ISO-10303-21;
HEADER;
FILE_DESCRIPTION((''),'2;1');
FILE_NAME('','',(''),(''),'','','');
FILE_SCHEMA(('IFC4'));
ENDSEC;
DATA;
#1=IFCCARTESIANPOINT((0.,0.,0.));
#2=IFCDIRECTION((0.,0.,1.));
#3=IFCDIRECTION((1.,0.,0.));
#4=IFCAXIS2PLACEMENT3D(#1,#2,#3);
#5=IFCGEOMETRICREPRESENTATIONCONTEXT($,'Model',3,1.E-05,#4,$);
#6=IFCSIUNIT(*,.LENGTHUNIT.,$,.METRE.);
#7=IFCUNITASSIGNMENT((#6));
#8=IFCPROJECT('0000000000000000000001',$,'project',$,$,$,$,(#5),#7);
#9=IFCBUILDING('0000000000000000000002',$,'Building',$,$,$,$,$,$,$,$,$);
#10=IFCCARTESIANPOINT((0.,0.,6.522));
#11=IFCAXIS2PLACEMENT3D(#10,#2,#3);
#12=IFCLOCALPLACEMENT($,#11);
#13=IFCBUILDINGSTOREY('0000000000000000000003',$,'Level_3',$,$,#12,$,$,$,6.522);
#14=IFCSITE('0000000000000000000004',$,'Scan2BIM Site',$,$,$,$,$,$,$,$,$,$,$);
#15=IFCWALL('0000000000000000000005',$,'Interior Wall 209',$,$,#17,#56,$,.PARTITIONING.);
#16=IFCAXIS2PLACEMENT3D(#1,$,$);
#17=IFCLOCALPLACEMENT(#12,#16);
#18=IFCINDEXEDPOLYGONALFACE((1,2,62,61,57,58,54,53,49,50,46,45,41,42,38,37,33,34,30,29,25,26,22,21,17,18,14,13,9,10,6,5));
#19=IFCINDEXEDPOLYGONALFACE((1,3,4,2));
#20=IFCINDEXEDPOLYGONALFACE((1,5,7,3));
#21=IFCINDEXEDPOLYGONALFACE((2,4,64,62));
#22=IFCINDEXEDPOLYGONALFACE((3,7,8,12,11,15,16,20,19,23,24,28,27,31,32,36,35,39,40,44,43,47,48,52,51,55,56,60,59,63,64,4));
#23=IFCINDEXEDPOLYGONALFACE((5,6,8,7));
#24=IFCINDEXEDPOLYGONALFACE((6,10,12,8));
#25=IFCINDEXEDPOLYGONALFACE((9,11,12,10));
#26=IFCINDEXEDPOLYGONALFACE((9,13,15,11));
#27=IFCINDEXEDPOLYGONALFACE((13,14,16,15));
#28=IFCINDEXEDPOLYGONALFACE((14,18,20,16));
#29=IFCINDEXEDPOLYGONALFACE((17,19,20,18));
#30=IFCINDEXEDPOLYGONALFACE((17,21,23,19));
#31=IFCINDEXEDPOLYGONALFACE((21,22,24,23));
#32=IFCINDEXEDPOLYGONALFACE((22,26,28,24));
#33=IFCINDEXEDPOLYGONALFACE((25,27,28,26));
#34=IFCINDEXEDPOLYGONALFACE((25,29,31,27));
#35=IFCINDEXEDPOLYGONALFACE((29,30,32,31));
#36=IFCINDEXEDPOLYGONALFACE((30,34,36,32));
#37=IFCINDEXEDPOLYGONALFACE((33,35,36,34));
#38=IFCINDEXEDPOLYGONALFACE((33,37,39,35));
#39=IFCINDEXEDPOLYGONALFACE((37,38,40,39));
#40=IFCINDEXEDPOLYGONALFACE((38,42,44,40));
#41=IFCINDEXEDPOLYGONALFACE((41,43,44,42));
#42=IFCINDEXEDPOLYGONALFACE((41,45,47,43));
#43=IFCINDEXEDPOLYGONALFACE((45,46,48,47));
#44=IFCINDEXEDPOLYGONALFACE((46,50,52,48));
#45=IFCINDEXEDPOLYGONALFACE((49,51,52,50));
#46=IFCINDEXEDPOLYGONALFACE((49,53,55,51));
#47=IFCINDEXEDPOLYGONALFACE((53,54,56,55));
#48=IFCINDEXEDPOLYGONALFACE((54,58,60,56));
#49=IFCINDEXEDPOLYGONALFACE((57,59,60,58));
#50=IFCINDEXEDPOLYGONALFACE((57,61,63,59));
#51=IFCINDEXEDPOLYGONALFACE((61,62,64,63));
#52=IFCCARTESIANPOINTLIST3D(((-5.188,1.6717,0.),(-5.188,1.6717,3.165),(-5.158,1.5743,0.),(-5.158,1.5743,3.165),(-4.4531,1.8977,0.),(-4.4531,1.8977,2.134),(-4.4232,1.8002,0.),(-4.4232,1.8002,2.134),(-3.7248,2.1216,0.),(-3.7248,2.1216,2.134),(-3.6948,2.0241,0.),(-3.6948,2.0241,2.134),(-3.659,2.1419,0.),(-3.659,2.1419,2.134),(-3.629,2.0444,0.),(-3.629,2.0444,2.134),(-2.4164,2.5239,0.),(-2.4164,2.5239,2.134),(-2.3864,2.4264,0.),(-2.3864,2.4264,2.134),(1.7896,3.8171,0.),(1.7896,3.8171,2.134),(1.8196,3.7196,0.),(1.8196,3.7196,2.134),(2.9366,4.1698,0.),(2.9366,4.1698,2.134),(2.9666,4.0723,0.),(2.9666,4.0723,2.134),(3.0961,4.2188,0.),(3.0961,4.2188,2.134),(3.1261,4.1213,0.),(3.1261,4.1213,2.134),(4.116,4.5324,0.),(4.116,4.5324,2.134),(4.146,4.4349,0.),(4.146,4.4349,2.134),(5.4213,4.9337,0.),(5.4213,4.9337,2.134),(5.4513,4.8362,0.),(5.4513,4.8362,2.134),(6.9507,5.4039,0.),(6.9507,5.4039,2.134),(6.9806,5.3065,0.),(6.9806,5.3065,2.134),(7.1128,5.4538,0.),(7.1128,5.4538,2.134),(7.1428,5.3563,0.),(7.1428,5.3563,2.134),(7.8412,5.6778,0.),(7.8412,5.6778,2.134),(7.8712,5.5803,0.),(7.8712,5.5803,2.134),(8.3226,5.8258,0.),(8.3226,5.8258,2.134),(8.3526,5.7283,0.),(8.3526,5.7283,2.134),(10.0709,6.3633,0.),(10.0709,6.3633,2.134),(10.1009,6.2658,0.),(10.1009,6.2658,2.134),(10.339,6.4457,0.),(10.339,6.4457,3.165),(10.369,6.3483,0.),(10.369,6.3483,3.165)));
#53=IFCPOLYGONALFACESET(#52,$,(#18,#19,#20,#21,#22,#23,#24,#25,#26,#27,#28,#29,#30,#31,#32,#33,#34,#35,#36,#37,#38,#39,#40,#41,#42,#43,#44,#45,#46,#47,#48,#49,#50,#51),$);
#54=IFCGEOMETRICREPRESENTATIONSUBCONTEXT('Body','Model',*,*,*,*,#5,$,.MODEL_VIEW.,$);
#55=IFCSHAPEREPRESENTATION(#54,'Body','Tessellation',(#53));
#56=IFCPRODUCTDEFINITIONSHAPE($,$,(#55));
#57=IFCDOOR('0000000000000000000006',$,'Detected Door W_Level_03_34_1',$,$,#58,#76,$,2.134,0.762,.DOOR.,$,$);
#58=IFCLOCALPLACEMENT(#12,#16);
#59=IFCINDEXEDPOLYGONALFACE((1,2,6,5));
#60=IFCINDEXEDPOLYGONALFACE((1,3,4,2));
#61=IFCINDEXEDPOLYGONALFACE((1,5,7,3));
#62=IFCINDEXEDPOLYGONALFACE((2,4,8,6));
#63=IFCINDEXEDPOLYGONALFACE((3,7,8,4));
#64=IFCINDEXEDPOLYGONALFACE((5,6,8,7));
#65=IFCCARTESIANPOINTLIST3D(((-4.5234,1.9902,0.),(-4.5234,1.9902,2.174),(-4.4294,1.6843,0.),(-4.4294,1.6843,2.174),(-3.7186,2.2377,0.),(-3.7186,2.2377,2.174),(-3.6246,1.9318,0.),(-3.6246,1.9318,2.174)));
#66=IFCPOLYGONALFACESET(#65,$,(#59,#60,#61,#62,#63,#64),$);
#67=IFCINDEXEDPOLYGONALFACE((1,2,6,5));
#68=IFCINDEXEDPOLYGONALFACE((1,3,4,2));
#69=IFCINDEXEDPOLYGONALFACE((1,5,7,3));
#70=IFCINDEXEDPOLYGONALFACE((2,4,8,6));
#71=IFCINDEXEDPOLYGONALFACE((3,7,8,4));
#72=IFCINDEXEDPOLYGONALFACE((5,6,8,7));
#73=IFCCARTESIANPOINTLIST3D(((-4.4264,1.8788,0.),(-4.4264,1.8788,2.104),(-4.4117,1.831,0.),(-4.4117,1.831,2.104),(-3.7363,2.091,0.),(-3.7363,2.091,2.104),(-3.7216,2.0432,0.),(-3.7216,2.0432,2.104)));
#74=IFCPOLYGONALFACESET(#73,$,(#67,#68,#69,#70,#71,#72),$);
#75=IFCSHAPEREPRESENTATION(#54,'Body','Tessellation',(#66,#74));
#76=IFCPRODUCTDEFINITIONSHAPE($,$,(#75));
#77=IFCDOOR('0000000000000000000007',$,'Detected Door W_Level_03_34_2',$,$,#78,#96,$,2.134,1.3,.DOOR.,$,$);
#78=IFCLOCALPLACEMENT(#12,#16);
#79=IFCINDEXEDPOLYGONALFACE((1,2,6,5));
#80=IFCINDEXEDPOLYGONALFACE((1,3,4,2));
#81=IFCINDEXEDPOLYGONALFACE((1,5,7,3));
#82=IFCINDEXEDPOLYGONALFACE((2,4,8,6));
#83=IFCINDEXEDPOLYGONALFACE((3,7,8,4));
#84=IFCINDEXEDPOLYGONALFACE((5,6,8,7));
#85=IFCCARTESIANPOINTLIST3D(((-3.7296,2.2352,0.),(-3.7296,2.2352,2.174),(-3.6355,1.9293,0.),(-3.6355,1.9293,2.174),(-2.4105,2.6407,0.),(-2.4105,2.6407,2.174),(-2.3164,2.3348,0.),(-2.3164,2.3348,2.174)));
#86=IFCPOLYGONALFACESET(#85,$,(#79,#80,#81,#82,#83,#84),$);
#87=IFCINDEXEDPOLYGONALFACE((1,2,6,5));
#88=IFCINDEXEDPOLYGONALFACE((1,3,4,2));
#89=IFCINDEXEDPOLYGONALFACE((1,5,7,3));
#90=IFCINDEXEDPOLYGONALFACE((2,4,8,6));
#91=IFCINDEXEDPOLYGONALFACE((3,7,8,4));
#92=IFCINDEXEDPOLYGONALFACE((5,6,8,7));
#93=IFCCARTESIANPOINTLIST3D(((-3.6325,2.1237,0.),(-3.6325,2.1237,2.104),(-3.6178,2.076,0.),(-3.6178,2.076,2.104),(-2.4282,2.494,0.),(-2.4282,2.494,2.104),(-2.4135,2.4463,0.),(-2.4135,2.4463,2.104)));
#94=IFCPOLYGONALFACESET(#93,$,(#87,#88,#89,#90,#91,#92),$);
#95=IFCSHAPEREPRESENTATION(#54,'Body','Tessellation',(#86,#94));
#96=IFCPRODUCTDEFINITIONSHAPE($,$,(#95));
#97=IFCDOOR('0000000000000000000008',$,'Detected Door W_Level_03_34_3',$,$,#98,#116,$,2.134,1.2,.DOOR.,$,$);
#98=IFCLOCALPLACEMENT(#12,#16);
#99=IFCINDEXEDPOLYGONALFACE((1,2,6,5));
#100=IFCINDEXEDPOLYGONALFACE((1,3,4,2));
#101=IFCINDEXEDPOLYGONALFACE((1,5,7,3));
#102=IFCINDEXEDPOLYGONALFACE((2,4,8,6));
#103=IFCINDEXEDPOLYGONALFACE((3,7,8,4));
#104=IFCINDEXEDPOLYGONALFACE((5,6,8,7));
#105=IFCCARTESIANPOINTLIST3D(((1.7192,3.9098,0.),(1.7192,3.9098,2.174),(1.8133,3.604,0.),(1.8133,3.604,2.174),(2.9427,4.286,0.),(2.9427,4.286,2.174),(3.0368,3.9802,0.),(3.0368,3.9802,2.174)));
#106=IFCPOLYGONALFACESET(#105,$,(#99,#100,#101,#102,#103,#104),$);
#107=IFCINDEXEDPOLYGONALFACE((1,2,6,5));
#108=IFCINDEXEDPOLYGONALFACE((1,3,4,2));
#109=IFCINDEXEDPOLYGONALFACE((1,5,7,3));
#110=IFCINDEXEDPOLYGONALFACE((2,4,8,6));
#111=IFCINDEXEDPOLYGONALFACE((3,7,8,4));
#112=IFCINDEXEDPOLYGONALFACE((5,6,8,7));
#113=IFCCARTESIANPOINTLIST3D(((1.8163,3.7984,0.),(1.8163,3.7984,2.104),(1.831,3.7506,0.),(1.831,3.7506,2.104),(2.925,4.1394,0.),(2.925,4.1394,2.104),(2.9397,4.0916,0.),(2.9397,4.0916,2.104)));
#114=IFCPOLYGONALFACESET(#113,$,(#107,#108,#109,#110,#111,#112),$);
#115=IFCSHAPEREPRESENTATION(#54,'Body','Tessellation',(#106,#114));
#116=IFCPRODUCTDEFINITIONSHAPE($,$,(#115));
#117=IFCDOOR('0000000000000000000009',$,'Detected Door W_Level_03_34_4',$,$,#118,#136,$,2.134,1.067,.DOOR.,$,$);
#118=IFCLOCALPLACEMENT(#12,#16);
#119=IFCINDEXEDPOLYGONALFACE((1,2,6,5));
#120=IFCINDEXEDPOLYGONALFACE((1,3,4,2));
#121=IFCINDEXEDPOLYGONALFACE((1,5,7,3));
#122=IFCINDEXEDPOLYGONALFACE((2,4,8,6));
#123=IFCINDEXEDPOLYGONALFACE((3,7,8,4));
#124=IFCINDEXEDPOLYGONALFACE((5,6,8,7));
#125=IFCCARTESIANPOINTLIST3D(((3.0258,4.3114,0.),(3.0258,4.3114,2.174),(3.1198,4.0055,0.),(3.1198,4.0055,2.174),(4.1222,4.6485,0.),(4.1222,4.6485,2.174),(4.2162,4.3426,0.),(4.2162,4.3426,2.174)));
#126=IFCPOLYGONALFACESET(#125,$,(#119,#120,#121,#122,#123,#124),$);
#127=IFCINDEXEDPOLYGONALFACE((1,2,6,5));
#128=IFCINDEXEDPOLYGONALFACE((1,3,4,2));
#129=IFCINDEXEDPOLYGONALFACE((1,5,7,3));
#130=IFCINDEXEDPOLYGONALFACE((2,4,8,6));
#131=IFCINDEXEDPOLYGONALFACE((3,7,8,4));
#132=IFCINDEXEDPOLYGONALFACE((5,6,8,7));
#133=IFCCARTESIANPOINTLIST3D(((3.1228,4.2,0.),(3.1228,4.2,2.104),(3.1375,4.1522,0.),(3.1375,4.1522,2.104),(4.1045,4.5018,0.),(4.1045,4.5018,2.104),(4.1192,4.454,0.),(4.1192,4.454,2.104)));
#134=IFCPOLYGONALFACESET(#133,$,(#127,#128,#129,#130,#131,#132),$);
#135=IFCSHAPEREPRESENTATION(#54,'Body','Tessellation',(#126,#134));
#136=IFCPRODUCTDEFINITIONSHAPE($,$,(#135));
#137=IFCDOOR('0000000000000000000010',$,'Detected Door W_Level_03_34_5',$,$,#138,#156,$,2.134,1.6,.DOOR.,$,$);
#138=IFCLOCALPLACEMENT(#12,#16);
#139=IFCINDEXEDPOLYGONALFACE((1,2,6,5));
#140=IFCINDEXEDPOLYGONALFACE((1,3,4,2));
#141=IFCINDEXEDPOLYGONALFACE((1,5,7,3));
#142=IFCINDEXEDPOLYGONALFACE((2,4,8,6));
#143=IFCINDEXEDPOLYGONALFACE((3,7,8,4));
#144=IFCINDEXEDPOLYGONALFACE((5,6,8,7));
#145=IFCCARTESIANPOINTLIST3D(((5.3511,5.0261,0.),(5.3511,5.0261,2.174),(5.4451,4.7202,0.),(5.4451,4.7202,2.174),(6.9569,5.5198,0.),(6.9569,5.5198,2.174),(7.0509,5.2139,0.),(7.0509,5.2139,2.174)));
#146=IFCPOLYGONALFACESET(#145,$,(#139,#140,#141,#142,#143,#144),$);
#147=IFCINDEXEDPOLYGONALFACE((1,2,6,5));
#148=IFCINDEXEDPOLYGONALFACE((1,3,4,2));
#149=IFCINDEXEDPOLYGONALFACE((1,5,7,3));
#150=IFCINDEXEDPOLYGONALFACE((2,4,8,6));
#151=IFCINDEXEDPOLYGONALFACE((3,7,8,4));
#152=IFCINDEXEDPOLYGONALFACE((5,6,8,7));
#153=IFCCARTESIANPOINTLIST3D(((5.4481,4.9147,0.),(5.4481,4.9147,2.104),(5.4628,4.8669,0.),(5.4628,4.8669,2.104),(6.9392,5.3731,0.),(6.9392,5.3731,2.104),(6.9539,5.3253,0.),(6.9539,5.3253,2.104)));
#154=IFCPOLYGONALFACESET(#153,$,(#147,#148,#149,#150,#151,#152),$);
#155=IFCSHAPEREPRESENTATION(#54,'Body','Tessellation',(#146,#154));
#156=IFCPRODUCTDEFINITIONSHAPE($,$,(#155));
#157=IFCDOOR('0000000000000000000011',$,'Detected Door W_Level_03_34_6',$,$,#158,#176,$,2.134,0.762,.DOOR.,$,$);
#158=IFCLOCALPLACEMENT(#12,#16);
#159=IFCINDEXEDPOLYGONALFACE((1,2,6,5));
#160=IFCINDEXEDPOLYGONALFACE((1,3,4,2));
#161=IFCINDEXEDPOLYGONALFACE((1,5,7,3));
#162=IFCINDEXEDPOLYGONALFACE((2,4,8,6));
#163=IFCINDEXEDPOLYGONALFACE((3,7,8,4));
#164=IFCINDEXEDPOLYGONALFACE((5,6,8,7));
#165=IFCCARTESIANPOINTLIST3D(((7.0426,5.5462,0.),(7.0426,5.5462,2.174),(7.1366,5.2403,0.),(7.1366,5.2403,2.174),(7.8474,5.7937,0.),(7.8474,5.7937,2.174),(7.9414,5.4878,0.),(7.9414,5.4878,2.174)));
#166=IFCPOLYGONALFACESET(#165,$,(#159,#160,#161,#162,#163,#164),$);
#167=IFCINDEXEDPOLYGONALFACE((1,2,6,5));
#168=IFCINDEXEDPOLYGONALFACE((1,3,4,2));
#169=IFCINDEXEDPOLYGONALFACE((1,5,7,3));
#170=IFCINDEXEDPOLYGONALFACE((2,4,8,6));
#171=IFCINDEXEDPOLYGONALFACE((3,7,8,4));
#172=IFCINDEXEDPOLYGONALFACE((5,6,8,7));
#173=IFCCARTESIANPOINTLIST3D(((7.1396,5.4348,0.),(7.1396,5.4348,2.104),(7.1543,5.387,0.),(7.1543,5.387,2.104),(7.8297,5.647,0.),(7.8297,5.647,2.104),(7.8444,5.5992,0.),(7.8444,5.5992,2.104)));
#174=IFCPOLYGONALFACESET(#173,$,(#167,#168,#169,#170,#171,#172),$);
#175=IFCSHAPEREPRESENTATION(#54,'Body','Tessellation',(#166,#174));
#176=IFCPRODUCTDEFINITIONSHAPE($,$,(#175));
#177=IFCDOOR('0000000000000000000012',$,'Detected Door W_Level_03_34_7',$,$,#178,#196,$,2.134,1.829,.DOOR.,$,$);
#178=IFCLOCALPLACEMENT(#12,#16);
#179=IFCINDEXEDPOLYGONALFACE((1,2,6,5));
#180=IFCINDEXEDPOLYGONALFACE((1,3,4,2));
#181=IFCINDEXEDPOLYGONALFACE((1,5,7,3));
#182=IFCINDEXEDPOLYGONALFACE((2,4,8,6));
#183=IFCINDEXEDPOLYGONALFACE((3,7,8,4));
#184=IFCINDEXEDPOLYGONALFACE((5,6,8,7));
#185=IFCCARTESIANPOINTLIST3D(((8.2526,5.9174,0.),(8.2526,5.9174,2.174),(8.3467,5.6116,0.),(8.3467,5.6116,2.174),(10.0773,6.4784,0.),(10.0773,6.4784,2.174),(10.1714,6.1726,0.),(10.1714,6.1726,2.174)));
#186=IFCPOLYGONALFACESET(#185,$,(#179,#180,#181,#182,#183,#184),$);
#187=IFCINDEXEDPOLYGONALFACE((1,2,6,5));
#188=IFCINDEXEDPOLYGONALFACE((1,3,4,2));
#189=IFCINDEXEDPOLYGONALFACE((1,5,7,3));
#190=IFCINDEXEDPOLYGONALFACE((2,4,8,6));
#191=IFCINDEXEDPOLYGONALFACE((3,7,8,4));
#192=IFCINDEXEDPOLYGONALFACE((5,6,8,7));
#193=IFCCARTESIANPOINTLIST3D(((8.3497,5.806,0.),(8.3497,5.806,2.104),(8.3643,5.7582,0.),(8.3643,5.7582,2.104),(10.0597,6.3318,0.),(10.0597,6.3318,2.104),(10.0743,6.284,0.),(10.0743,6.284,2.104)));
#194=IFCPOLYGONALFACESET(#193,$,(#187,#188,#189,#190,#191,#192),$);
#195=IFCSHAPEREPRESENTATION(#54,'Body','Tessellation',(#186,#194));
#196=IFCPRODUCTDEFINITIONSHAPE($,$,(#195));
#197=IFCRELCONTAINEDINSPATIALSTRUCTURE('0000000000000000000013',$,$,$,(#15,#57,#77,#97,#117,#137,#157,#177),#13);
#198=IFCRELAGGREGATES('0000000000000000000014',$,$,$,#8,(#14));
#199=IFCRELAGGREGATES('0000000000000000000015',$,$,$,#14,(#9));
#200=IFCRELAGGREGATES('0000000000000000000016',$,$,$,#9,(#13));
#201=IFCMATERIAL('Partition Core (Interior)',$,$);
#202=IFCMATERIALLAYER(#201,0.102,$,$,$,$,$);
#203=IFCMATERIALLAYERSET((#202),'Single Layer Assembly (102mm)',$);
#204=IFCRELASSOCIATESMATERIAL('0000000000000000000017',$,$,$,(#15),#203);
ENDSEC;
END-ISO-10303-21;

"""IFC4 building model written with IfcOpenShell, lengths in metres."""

from ifc_helpers import new_model, si_unit, frame, origin, origin_with_axes, place, context, subcontext, project, spatial, rectangle, extrude, material, layer, layer_set, element, fill, save


model = new_model("IFC4")

# Units and contexts
model_context = context("Model", 3, precision=1e-05, world=origin_with_axes())
body_context = subcontext(model_context, "Body", "Model", "MODEL_VIEW")
ifc_project = project(units=[si_unit("LENGTHUNIT", "METRE")], contexts=[model_context])

# Site, building, storey
site = spatial("IfcSite", under=ifc_project, Name="Scan2BIM Site")
building = spatial("IfcBuilding", under=site, Name="Building")
storey_placement = place(None, frame((0.0, 0.0, 6.522), z_axis=(0.0, 0.0, 1.0), x_axis=(1.0, 0.0, 0.0)))
storey = spatial("IfcBuildingStorey", under=building, at=storey_placement, Name="Level_3", Elevation=6.522)

# Wall, openings, doors
ifc_material_1 = material(Name="Partition Core (Interior)")
ifc_layer_1 = layer(ifc_material_1, 0.102)
ifc_layer_set_1 = layer_set([ifc_layer_1], Name="Single Layer Assembly (102mm)")
wall_1_placement = place(storey_placement, frame((2.5905, 4.01, 0.0), z_axis=(0.0, 0.0, 1.0), x_axis=(0.95584, 0.293887, 0.0)))
wall_1 = element("IfcWall", 1, at=wall_1_placement, inside=storey, material=ifc_layer_set_1, Name="Interior Wall 209", PredefinedType="PARTITIONING", context=body_context, shape_type="SweptSolid", body=[
    extrude(rectangle(XDim=16.2443, YDim=0.102), origin(), (0.0, 0.0, 1.0), 3.165),
])
opening_1_placement = place(None, frame((-4.074, 1.961, 6.522), z_axis=(0.0, 0.0, 1.0), x_axis=(0.95584, 0.293887, 0.0)))
opening_1 = element("IfcOpeningElement", 2, at=opening_1_placement, cuts=wall_1, PredefinedType="OPENING", context=body_context, shape_type="SweptSolid", body=[
    extrude(rectangle(XDim=0.762, YDim=0.202), origin(), (0.0, 0.0, 1.0), 2.134),
])
opening_2_placement = place(None, frame((-3.023, 2.285, 6.522), z_axis=(0.0, 0.0, 1.0), x_axis=(0.95584, 0.293887, 0.0)))
opening_2 = element("IfcOpeningElement", 3, at=opening_2_placement, cuts=wall_1, PredefinedType="OPENING", context=body_context, shape_type="SweptSolid", body=[
    extrude(rectangle(XDim=1.3, YDim=0.202), origin(), (0.0, 0.0, 1.0), 2.134),
])
opening_3_placement = place(None, frame((2.378, 3.945, 6.522), z_axis=(0.0, 0.0, 1.0), x_axis=(0.95584, 0.293887, 0.0)))
opening_3 = element("IfcOpeningElement", 4, at=opening_3_placement, cuts=wall_1, PredefinedType="OPENING", context=body_context, shape_type="SweptSolid", body=[
    extrude(rectangle(XDim=1.2, YDim=0.202), origin(), (0.0, 0.0, 1.0), 2.134),
])
opening_4_placement = place(None, frame((3.621, 4.327, 6.522), z_axis=(0.0, 0.0, 1.0), x_axis=(0.95584, 0.293887, 0.0)))
opening_4 = element("IfcOpeningElement", 5, at=opening_4_placement, cuts=wall_1, PredefinedType="OPENING", context=body_context, shape_type="SweptSolid", body=[
    extrude(rectangle(XDim=1.067, YDim=0.202), origin(), (0.0, 0.0, 1.0), 2.134),
])
opening_5_placement = place(None, frame((6.201, 5.12, 6.522), z_axis=(0.0, 0.0, 1.0), x_axis=(0.95584, 0.293887, 0.0)))
opening_5 = element("IfcOpeningElement", 6, at=opening_5_placement, cuts=wall_1, PredefinedType="OPENING", context=body_context, shape_type="SweptSolid", body=[
    extrude(rectangle(XDim=1.6, YDim=0.202), origin(), (0.0, 0.0, 1.0), 2.134),
])
opening_6_placement = place(None, frame((7.492, 5.517, 6.522), z_axis=(0.0, 0.0, 1.0), x_axis=(0.95584, 0.293887, 0.0)))
opening_6 = element("IfcOpeningElement", 7, at=opening_6_placement, cuts=wall_1, PredefinedType="OPENING", context=body_context, shape_type="SweptSolid", body=[
    extrude(rectangle(XDim=0.762, YDim=0.202), origin(), (0.0, 0.0, 1.0), 2.134),
])
opening_7_placement = place(None, frame((9.212, 6.045, 6.522), z_axis=(0.0, 0.0, 1.0), x_axis=(0.95584, 0.293887, 0.0)))
opening_7 = element("IfcOpeningElement", 8, at=opening_7_placement, cuts=wall_1, PredefinedType="OPENING", context=body_context, shape_type="SweptSolid", body=[
    extrude(rectangle(XDim=1.829, YDim=0.202), origin(), (0.0, 0.0, 1.0), 2.134),
])
door_1_placement = place(opening_1_placement, frame((0.0, 0.0, 0.0), z_axis=(0.0, 0.0, 1.0), x_axis=(1.0, 0.0, 0.0)))
door_1 = element("IfcDoor", 9, at=door_1_placement, inside=storey, Name="Detected Door W_Level_03_34_1", OverallHeight=2.134, OverallWidth=0.762, PredefinedType="DOOR", context=body_context, shape_type="SweptSolid", body=[
    extrude(rectangle(XDim=0.842, YDim=0.32), origin(), (0.0, 0.0, 1.0), 2.174),
    extrude(rectangle(XDim=0.722, YDim=0.05), origin(), (0.0, 0.0, 1.0), 2.104),
])
fill(opening_1, door_1)
door_2_placement = place(opening_2_placement, frame((0.0, 0.0, 0.0), z_axis=(0.0, 0.0, 1.0), x_axis=(1.0, 0.0, 0.0)))
door_2 = element("IfcDoor", 10, at=door_2_placement, inside=storey, Name="Detected Door W_Level_03_34_2", OverallHeight=2.134, OverallWidth=1.3, PredefinedType="DOOR", context=body_context, shape_type="SweptSolid", body=[
    extrude(rectangle(XDim=1.38, YDim=0.32), origin(), (0.0, 0.0, 1.0), 2.174),
    extrude(rectangle(XDim=1.26, YDim=0.05), origin(), (0.0, 0.0, 1.0), 2.104),
])
fill(opening_2, door_2)
door_3_placement = place(opening_3_placement, frame((0.0, 0.0, 0.0), z_axis=(0.0, 0.0, 1.0), x_axis=(1.0, 0.0, 0.0)))
door_3 = element("IfcDoor", 11, at=door_3_placement, inside=storey, Name="Detected Door W_Level_03_34_3", OverallHeight=2.134, OverallWidth=1.2, PredefinedType="DOOR", context=body_context, shape_type="SweptSolid", body=[
    extrude(rectangle(XDim=1.28, YDim=0.32), origin(), (0.0, 0.0, 1.0), 2.174),
    extrude(rectangle(XDim=1.16, YDim=0.05), origin(), (0.0, 0.0, 1.0), 2.104),
])
fill(opening_3, door_3)
door_4_placement = place(opening_4_placement, frame((0.0, 0.0, 0.0), z_axis=(0.0, 0.0, 1.0), x_axis=(1.0, 0.0, 0.0)))
door_4 = element("IfcDoor", 12, at=door_4_placement, inside=storey, Name="Detected Door W_Level_03_34_4", OverallHeight=2.134, OverallWidth=1.067, PredefinedType="DOOR", context=body_context, shape_type="SweptSolid", body=[
    extrude(rectangle(XDim=1.147, YDim=0.32), origin(), (0.0, 0.0, 1.0), 2.174),
    extrude(rectangle(XDim=1.027, YDim=0.05), origin(), (0.0, 0.0, 1.0), 2.104),
])
fill(opening_4, door_4)
door_5_placement = place(opening_5_placement, frame((0.0, 0.0, 0.0), z_axis=(0.0, 0.0, 1.0), x_axis=(1.0, 0.0, 0.0)))
door_5 = element("IfcDoor", 13, at=door_5_placement, inside=storey, Name="Detected Door W_Level_03_34_5", OverallHeight=2.134, OverallWidth=1.6, PredefinedType="DOOR", context=body_context, shape_type="SweptSolid", body=[
    extrude(rectangle(XDim=1.68, YDim=0.32), origin(), (0.0, 0.0, 1.0), 2.174),
    extrude(rectangle(XDim=1.56, YDim=0.05), origin(), (0.0, 0.0, 1.0), 2.104),
])
fill(opening_5, door_5)
door_6_placement = place(opening_6_placement, frame((0.0, 0.0, 0.0), z_axis=(0.0, 0.0, 1.0), x_axis=(1.0, 0.0, 0.0)))
door_6 = element("IfcDoor", 14, at=door_6_placement, inside=storey, Name="Detected Door W_Level_03_34_6", OverallHeight=2.134, OverallWidth=0.762, PredefinedType="DOOR", context=body_context, shape_type="SweptSolid", body=[
    extrude(rectangle(XDim=0.842, YDim=0.32), origin(), (0.0, 0.0, 1.0), 2.174),
    extrude(rectangle(XDim=0.722, YDim=0.05), origin(), (0.0, 0.0, 1.0), 2.104),
])
fill(opening_6, door_6)
door_7_placement = place(opening_7_placement, frame((0.0, 0.0, 0.0), z_axis=(0.0, 0.0, 1.0), x_axis=(1.0, 0.0, 0.0)))
door_7 = element("IfcDoor", 15, at=door_7_placement, inside=storey, Name="Detected Door W_Level_03_34_7", OverallHeight=2.134, OverallWidth=1.829, PredefinedType="DOOR", context=body_context, shape_type="SweptSolid", body=[
    extrude(rectangle(XDim=1.909, YDim=0.32), origin(), (0.0, 0.0, 1.0), 2.174),
    extrude(rectangle(XDim=1.789, YDim=0.05), origin(), (0.0, 0.0, 1.0), 2.104),
])
fill(opening_7, door_7)

save(model, "model.ifc")
